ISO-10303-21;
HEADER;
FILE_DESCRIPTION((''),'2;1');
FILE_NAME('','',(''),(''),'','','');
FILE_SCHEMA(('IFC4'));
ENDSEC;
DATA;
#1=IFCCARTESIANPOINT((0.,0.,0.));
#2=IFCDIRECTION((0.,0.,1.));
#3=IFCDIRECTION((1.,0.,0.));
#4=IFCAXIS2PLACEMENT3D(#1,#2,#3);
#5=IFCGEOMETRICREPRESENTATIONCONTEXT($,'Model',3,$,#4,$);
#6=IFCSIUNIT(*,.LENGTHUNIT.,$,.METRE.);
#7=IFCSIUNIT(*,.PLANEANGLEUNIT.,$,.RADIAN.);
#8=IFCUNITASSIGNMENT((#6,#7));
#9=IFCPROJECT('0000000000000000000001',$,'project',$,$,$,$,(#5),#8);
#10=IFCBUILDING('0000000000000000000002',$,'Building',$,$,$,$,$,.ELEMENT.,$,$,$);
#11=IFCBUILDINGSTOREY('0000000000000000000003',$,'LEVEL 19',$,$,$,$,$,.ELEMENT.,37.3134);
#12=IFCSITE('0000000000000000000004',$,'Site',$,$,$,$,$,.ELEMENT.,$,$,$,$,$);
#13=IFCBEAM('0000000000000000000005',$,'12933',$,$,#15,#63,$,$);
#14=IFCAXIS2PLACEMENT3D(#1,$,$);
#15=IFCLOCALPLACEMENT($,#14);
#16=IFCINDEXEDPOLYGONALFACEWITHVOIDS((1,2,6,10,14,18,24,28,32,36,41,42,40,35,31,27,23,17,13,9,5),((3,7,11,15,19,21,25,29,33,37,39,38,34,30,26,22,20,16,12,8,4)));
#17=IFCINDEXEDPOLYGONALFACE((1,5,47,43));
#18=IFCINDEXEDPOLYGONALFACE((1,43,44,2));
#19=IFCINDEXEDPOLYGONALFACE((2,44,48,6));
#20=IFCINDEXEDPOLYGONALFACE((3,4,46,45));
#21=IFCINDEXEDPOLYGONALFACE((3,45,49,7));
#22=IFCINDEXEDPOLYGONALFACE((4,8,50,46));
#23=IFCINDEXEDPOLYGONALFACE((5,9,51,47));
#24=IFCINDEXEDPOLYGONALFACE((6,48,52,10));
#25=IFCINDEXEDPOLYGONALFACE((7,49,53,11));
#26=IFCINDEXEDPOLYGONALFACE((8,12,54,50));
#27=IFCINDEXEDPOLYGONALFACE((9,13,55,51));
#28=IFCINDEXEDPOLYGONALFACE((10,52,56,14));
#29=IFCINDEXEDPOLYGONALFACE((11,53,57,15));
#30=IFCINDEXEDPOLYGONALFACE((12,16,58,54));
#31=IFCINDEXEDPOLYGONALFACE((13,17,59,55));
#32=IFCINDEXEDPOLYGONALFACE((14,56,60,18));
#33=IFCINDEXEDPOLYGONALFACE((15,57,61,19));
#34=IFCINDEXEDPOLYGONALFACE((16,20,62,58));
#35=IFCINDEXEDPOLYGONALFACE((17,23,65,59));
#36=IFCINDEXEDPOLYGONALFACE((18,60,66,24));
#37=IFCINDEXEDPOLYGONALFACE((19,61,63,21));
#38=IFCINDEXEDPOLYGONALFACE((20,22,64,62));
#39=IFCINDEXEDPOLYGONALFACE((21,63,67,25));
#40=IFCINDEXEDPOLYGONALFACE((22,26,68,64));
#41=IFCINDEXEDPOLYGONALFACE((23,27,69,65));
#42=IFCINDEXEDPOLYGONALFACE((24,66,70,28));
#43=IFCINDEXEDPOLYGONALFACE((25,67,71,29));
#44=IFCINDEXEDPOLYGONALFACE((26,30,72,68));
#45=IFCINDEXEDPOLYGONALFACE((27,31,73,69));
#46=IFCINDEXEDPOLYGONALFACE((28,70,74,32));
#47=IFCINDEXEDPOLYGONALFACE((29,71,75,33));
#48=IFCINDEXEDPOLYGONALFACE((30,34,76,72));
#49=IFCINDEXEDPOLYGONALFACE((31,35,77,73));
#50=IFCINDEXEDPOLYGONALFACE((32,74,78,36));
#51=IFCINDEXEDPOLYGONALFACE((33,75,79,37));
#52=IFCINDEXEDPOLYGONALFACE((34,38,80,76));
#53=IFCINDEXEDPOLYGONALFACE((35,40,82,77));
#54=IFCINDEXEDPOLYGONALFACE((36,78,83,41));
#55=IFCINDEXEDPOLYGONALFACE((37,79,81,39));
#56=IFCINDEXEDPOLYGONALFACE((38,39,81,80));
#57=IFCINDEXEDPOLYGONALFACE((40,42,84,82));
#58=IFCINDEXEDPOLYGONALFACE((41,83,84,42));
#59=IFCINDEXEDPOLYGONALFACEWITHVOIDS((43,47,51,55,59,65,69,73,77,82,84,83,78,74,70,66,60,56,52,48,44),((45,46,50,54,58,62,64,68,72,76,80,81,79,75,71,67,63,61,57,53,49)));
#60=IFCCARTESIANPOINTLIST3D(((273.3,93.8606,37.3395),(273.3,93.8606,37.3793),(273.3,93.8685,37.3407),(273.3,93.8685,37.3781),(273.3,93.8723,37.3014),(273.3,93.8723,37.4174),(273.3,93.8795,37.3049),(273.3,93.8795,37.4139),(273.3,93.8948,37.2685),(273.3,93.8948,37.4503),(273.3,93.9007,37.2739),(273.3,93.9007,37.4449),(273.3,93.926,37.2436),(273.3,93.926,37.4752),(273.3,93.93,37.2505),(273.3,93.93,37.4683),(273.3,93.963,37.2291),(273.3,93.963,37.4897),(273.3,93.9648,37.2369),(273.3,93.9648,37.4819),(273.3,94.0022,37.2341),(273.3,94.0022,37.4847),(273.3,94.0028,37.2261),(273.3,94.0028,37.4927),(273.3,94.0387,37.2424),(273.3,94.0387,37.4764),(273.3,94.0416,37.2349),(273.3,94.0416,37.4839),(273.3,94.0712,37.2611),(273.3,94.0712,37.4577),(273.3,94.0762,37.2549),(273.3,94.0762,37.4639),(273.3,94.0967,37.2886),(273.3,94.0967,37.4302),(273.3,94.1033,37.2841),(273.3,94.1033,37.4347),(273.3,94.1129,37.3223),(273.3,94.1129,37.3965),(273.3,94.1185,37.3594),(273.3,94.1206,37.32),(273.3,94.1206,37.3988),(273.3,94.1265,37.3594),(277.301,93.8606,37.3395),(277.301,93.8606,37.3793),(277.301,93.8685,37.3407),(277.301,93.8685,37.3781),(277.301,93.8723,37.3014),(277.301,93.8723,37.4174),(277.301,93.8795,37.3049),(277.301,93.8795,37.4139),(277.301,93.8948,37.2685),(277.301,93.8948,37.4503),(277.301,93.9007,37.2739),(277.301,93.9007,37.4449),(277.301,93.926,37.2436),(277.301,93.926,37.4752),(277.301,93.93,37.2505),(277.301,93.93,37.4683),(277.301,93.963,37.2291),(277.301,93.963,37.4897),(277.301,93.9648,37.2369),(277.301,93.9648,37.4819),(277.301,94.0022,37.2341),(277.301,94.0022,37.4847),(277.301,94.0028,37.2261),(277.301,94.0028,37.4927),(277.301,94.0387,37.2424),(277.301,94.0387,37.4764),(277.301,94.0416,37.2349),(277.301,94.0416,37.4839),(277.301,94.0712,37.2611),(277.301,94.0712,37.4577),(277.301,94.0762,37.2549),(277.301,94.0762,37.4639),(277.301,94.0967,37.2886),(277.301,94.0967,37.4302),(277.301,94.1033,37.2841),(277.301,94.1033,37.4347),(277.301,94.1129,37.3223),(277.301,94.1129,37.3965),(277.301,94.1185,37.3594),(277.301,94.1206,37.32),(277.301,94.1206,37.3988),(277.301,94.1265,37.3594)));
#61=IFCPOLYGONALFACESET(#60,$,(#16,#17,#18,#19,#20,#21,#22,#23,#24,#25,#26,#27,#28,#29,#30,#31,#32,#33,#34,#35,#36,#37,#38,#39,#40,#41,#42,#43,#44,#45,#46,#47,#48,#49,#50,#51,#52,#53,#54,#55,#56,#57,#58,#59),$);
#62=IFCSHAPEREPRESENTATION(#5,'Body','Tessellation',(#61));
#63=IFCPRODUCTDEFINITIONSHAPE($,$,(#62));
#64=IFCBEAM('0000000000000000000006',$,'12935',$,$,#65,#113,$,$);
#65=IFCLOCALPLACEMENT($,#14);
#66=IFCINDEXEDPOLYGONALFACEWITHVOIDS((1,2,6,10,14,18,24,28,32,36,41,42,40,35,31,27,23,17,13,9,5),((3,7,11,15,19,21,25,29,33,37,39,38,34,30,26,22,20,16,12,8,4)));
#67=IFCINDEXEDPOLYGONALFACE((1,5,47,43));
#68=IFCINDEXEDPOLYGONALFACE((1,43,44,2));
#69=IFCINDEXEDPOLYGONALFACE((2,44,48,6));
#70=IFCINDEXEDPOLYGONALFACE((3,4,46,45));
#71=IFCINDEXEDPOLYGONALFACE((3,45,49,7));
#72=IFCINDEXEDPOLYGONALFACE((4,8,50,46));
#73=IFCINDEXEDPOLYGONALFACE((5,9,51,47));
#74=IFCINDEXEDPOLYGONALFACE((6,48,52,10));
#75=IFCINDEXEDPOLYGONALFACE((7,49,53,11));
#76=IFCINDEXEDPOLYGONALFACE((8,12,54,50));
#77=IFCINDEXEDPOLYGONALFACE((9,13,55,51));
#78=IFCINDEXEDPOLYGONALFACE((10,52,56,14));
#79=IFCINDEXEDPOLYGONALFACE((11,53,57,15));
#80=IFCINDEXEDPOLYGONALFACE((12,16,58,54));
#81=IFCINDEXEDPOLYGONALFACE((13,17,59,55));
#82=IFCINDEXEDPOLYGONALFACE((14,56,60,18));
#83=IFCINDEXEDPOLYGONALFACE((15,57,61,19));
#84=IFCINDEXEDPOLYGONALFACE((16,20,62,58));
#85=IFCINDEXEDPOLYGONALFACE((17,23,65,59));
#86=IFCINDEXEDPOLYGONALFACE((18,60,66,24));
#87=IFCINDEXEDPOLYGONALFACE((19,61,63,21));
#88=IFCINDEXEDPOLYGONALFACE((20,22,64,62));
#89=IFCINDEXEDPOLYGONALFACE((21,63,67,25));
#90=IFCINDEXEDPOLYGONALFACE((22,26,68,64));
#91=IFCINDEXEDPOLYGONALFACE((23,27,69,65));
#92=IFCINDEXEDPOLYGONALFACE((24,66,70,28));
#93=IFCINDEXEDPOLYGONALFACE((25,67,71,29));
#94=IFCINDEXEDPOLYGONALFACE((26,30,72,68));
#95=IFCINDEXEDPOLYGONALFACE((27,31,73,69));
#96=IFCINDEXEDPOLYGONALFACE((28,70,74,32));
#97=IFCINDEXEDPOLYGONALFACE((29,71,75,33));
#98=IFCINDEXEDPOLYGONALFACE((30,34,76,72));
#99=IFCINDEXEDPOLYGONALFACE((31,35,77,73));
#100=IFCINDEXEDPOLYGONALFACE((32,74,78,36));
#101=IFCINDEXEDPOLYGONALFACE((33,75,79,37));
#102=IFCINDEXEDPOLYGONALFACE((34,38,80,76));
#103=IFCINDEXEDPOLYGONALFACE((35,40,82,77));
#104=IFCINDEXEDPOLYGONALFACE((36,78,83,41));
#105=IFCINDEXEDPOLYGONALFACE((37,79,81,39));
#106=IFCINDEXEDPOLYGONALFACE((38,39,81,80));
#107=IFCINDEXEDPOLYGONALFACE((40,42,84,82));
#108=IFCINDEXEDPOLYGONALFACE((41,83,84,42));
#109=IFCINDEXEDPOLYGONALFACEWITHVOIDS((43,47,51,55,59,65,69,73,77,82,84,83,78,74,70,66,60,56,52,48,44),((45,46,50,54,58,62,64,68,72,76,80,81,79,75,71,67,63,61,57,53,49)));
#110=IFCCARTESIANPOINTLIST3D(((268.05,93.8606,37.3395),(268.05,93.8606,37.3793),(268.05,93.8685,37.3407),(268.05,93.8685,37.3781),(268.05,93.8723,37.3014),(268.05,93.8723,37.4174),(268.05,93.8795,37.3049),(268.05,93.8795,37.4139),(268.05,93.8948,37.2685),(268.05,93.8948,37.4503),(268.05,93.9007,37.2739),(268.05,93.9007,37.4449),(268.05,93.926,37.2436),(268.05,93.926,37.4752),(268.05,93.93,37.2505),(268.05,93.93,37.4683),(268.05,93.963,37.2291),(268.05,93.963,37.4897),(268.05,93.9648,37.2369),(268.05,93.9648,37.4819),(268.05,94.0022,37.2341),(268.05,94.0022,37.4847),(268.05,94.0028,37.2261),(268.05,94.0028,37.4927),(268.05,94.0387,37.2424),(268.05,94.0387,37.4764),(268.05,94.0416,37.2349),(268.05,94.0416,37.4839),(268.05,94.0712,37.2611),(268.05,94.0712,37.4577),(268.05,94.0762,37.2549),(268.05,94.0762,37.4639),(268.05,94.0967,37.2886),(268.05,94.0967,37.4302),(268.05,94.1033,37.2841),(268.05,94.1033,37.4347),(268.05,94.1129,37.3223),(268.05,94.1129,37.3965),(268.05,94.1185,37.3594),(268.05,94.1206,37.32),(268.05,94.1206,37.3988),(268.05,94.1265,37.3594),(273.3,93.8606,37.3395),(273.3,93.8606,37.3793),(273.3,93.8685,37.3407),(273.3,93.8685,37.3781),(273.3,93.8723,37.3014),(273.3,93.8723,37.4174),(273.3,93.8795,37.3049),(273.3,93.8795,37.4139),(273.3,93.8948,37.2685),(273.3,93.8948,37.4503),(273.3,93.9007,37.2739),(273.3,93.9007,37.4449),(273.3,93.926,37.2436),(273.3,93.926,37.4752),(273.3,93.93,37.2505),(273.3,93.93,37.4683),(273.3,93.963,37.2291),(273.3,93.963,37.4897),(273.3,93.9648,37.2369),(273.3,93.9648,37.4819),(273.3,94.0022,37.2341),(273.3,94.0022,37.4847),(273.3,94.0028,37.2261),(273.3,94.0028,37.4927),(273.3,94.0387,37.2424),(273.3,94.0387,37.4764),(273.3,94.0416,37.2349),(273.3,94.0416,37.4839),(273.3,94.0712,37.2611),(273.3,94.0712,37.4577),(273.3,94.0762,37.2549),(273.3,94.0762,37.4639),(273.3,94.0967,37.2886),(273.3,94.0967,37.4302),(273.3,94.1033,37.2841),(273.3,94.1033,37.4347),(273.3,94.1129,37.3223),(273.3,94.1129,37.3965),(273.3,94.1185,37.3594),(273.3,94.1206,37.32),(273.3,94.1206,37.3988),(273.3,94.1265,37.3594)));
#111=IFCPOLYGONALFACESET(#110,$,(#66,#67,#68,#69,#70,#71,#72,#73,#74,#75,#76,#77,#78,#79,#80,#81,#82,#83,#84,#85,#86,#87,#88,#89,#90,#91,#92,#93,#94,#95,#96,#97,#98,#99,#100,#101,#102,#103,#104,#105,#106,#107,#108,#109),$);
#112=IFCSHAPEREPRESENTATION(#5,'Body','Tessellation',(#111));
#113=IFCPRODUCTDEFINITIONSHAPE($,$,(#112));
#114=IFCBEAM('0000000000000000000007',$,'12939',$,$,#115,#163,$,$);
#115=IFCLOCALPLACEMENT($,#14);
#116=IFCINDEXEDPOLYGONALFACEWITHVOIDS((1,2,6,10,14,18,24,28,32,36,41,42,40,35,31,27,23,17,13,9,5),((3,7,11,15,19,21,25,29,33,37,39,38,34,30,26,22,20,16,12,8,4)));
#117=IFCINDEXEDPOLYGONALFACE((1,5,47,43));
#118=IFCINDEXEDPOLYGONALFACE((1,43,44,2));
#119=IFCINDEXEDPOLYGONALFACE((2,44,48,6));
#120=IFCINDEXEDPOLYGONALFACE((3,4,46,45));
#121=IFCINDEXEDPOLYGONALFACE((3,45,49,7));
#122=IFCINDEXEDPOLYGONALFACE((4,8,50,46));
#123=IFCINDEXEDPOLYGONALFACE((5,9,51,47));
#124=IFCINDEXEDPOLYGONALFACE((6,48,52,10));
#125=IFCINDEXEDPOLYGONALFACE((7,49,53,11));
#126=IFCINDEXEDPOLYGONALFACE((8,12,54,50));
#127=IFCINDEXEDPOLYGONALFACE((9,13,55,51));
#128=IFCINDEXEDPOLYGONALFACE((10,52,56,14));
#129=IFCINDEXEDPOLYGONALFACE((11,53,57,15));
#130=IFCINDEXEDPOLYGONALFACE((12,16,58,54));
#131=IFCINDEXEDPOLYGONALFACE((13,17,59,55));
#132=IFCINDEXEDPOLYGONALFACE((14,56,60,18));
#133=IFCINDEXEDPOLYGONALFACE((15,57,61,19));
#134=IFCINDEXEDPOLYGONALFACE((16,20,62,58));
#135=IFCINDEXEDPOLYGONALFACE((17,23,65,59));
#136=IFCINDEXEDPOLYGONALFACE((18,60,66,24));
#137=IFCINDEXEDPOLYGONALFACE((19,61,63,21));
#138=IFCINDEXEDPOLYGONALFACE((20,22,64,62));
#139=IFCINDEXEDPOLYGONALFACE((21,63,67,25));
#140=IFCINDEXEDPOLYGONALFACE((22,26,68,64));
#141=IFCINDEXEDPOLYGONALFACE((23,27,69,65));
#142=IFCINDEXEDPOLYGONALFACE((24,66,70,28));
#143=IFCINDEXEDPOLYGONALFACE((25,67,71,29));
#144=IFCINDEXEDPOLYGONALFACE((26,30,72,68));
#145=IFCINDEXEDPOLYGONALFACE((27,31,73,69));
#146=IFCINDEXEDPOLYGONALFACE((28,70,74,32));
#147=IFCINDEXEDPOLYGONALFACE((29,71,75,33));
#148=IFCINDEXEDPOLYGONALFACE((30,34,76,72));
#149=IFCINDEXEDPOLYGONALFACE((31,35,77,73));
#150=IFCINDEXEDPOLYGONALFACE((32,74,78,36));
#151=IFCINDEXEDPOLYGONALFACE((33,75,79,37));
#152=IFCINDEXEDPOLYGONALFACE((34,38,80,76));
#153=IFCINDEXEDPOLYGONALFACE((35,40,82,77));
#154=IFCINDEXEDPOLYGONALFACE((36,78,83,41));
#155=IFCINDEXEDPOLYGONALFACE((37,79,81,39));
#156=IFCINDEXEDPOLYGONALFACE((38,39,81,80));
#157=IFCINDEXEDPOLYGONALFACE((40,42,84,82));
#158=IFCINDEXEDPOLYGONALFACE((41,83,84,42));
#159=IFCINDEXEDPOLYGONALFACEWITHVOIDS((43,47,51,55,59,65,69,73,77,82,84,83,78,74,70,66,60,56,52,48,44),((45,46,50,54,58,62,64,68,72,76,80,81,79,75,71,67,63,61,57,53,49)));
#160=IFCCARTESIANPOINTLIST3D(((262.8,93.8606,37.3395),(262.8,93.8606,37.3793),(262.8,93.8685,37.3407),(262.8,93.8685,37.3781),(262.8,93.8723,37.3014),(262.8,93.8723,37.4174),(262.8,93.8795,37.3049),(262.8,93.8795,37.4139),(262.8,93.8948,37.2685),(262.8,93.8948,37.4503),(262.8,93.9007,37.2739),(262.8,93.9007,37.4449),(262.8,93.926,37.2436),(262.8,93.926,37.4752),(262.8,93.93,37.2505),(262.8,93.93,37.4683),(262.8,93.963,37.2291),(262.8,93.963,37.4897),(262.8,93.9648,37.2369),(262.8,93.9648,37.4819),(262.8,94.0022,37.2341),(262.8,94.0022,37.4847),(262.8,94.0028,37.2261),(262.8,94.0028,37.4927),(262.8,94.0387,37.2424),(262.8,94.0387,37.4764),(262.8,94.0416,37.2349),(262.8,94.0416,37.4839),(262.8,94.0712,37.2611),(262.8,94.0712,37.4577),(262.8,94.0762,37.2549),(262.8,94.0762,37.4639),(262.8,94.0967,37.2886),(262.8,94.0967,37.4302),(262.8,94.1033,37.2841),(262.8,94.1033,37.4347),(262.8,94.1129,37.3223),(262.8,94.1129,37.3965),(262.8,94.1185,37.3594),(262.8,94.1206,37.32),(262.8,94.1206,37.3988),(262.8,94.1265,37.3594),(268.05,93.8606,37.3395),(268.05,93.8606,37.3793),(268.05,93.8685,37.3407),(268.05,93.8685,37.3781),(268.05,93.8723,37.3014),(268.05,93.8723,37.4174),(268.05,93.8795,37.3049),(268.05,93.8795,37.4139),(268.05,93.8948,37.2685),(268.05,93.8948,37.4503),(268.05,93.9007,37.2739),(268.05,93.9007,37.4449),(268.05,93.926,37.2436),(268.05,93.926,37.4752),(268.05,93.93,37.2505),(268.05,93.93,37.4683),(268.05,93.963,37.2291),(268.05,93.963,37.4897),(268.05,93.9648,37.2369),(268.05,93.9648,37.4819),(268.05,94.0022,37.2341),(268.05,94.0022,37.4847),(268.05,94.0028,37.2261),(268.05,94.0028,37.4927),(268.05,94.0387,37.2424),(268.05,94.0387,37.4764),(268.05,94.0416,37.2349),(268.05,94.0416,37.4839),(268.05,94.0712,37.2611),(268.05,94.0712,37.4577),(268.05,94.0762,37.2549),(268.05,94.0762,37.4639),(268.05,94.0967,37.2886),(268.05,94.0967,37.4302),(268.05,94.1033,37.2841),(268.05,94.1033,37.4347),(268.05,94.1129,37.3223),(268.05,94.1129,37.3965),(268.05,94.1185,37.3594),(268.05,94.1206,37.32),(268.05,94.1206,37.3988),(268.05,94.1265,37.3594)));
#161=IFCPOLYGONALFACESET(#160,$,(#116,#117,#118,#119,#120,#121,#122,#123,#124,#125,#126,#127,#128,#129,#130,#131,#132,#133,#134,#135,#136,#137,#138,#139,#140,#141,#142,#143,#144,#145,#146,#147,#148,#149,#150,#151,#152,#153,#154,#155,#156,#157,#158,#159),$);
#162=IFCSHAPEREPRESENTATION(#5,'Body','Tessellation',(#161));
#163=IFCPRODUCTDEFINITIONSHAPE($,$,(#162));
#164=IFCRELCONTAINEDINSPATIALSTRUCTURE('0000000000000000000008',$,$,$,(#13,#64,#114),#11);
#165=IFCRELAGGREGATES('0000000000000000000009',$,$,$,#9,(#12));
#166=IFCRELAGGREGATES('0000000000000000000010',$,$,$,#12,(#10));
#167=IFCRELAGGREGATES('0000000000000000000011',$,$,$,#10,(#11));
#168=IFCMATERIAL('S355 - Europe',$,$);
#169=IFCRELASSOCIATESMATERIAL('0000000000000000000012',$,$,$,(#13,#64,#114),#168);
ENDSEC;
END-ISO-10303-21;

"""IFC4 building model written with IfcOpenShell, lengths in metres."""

from ifc_helpers import new_model, si_unit, frame, origin_with_axes, origin_2d_with_axis, place, context, project, spatial, hollow_circle, extrude, material, material_profile, profile_set, profile_usage, element, save


model = new_model("IFC4")

# Units and contexts
model_context = context("Model", 3, world=origin_with_axes())
ifc_project = project(units=[si_unit("LENGTHUNIT", "METRE"), si_unit("PLANEANGLEUNIT", "RADIAN")], contexts=[model_context])

# Site, building, storey
site = spatial("IfcSite", under=ifc_project, Name="Site", CompositionType="ELEMENT")
building = spatial("IfcBuilding", under=site, Name="Building", CompositionType="ELEMENT")
storey = spatial("IfcBuildingStorey", under=building, Name="LEVEL 19", CompositionType="ELEMENT", Elevation=37.3134)

# Beams
ifc_material = material(Name="S355 - Europe")
ifc_material_profile_1 = material_profile(ifc_material, hollow_circle(Radius=0.1337, WallThickness=0.008, at=origin_2d_with_axis()))
ifc_profile_set_1 = profile_set([ifc_material_profile_1])
ifc_profile_usage_1 = profile_usage(ifc_profile_set_1, cardinal=10)
beam_1_placement = place(None, frame((273.3, 93.9928, 37.3594), z_axis=(1.0, 0.0, 0.0), x_axis=(0.0, 1.0, 0.0)))
element("IfcBeam", 1, at=beam_1_placement, inside=storey, material=ifc_profile_usage_1, Name="12933", context=model_context, shape_type="SweptSolid", body=[
    extrude(hollow_circle(Radius=0.1337, WallThickness=0.008, at=origin_2d_with_axis()), origin_with_axes(), (0.0, 0.0, 1.0), 4.001),
])
ifc_material_profile_2 = material_profile(ifc_material, hollow_circle(Radius=0.1337, WallThickness=0.008, at=origin_2d_with_axis()))
ifc_profile_set_2 = profile_set([ifc_material_profile_2])
ifc_profile_usage_2 = profile_usage(ifc_profile_set_2, cardinal=10)
beam_2_placement = place(None, frame((268.05, 93.9928, 37.3594), z_axis=(1.0, 0.0, 0.0), x_axis=(0.0, 1.0, 0.0)))
element("IfcBeam", 2, at=beam_2_placement, inside=storey, material=ifc_profile_usage_2, Name="12935", context=model_context, shape_type="SweptSolid", body=[
    extrude(hollow_circle(Radius=0.1337, WallThickness=0.008, at=origin_2d_with_axis()), origin_with_axes(), (0.0, 0.0, 1.0), 5.25),
])
ifc_material_profile_3 = material_profile(ifc_material, hollow_circle(Radius=0.1337, WallThickness=0.008, at=origin_2d_with_axis()))
ifc_profile_set_3 = profile_set([ifc_material_profile_3])
ifc_profile_usage_3 = profile_usage(ifc_profile_set_3, cardinal=10)
beam_3_placement = place(None, frame((262.8, 93.9928, 37.3594), z_axis=(1.0, 0.0, 0.0), x_axis=(0.0, 1.0, 0.0)))
element("IfcBeam", 3, at=beam_3_placement, inside=storey, material=ifc_profile_usage_3, Name="12939", context=model_context, shape_type="SweptSolid", body=[
    extrude(hollow_circle(Radius=0.1337, WallThickness=0.008, at=origin_2d_with_axis()), origin_with_axes(), (0.0, 0.0, 1.0), 5.25),
])

save(model, "model.ifc")
